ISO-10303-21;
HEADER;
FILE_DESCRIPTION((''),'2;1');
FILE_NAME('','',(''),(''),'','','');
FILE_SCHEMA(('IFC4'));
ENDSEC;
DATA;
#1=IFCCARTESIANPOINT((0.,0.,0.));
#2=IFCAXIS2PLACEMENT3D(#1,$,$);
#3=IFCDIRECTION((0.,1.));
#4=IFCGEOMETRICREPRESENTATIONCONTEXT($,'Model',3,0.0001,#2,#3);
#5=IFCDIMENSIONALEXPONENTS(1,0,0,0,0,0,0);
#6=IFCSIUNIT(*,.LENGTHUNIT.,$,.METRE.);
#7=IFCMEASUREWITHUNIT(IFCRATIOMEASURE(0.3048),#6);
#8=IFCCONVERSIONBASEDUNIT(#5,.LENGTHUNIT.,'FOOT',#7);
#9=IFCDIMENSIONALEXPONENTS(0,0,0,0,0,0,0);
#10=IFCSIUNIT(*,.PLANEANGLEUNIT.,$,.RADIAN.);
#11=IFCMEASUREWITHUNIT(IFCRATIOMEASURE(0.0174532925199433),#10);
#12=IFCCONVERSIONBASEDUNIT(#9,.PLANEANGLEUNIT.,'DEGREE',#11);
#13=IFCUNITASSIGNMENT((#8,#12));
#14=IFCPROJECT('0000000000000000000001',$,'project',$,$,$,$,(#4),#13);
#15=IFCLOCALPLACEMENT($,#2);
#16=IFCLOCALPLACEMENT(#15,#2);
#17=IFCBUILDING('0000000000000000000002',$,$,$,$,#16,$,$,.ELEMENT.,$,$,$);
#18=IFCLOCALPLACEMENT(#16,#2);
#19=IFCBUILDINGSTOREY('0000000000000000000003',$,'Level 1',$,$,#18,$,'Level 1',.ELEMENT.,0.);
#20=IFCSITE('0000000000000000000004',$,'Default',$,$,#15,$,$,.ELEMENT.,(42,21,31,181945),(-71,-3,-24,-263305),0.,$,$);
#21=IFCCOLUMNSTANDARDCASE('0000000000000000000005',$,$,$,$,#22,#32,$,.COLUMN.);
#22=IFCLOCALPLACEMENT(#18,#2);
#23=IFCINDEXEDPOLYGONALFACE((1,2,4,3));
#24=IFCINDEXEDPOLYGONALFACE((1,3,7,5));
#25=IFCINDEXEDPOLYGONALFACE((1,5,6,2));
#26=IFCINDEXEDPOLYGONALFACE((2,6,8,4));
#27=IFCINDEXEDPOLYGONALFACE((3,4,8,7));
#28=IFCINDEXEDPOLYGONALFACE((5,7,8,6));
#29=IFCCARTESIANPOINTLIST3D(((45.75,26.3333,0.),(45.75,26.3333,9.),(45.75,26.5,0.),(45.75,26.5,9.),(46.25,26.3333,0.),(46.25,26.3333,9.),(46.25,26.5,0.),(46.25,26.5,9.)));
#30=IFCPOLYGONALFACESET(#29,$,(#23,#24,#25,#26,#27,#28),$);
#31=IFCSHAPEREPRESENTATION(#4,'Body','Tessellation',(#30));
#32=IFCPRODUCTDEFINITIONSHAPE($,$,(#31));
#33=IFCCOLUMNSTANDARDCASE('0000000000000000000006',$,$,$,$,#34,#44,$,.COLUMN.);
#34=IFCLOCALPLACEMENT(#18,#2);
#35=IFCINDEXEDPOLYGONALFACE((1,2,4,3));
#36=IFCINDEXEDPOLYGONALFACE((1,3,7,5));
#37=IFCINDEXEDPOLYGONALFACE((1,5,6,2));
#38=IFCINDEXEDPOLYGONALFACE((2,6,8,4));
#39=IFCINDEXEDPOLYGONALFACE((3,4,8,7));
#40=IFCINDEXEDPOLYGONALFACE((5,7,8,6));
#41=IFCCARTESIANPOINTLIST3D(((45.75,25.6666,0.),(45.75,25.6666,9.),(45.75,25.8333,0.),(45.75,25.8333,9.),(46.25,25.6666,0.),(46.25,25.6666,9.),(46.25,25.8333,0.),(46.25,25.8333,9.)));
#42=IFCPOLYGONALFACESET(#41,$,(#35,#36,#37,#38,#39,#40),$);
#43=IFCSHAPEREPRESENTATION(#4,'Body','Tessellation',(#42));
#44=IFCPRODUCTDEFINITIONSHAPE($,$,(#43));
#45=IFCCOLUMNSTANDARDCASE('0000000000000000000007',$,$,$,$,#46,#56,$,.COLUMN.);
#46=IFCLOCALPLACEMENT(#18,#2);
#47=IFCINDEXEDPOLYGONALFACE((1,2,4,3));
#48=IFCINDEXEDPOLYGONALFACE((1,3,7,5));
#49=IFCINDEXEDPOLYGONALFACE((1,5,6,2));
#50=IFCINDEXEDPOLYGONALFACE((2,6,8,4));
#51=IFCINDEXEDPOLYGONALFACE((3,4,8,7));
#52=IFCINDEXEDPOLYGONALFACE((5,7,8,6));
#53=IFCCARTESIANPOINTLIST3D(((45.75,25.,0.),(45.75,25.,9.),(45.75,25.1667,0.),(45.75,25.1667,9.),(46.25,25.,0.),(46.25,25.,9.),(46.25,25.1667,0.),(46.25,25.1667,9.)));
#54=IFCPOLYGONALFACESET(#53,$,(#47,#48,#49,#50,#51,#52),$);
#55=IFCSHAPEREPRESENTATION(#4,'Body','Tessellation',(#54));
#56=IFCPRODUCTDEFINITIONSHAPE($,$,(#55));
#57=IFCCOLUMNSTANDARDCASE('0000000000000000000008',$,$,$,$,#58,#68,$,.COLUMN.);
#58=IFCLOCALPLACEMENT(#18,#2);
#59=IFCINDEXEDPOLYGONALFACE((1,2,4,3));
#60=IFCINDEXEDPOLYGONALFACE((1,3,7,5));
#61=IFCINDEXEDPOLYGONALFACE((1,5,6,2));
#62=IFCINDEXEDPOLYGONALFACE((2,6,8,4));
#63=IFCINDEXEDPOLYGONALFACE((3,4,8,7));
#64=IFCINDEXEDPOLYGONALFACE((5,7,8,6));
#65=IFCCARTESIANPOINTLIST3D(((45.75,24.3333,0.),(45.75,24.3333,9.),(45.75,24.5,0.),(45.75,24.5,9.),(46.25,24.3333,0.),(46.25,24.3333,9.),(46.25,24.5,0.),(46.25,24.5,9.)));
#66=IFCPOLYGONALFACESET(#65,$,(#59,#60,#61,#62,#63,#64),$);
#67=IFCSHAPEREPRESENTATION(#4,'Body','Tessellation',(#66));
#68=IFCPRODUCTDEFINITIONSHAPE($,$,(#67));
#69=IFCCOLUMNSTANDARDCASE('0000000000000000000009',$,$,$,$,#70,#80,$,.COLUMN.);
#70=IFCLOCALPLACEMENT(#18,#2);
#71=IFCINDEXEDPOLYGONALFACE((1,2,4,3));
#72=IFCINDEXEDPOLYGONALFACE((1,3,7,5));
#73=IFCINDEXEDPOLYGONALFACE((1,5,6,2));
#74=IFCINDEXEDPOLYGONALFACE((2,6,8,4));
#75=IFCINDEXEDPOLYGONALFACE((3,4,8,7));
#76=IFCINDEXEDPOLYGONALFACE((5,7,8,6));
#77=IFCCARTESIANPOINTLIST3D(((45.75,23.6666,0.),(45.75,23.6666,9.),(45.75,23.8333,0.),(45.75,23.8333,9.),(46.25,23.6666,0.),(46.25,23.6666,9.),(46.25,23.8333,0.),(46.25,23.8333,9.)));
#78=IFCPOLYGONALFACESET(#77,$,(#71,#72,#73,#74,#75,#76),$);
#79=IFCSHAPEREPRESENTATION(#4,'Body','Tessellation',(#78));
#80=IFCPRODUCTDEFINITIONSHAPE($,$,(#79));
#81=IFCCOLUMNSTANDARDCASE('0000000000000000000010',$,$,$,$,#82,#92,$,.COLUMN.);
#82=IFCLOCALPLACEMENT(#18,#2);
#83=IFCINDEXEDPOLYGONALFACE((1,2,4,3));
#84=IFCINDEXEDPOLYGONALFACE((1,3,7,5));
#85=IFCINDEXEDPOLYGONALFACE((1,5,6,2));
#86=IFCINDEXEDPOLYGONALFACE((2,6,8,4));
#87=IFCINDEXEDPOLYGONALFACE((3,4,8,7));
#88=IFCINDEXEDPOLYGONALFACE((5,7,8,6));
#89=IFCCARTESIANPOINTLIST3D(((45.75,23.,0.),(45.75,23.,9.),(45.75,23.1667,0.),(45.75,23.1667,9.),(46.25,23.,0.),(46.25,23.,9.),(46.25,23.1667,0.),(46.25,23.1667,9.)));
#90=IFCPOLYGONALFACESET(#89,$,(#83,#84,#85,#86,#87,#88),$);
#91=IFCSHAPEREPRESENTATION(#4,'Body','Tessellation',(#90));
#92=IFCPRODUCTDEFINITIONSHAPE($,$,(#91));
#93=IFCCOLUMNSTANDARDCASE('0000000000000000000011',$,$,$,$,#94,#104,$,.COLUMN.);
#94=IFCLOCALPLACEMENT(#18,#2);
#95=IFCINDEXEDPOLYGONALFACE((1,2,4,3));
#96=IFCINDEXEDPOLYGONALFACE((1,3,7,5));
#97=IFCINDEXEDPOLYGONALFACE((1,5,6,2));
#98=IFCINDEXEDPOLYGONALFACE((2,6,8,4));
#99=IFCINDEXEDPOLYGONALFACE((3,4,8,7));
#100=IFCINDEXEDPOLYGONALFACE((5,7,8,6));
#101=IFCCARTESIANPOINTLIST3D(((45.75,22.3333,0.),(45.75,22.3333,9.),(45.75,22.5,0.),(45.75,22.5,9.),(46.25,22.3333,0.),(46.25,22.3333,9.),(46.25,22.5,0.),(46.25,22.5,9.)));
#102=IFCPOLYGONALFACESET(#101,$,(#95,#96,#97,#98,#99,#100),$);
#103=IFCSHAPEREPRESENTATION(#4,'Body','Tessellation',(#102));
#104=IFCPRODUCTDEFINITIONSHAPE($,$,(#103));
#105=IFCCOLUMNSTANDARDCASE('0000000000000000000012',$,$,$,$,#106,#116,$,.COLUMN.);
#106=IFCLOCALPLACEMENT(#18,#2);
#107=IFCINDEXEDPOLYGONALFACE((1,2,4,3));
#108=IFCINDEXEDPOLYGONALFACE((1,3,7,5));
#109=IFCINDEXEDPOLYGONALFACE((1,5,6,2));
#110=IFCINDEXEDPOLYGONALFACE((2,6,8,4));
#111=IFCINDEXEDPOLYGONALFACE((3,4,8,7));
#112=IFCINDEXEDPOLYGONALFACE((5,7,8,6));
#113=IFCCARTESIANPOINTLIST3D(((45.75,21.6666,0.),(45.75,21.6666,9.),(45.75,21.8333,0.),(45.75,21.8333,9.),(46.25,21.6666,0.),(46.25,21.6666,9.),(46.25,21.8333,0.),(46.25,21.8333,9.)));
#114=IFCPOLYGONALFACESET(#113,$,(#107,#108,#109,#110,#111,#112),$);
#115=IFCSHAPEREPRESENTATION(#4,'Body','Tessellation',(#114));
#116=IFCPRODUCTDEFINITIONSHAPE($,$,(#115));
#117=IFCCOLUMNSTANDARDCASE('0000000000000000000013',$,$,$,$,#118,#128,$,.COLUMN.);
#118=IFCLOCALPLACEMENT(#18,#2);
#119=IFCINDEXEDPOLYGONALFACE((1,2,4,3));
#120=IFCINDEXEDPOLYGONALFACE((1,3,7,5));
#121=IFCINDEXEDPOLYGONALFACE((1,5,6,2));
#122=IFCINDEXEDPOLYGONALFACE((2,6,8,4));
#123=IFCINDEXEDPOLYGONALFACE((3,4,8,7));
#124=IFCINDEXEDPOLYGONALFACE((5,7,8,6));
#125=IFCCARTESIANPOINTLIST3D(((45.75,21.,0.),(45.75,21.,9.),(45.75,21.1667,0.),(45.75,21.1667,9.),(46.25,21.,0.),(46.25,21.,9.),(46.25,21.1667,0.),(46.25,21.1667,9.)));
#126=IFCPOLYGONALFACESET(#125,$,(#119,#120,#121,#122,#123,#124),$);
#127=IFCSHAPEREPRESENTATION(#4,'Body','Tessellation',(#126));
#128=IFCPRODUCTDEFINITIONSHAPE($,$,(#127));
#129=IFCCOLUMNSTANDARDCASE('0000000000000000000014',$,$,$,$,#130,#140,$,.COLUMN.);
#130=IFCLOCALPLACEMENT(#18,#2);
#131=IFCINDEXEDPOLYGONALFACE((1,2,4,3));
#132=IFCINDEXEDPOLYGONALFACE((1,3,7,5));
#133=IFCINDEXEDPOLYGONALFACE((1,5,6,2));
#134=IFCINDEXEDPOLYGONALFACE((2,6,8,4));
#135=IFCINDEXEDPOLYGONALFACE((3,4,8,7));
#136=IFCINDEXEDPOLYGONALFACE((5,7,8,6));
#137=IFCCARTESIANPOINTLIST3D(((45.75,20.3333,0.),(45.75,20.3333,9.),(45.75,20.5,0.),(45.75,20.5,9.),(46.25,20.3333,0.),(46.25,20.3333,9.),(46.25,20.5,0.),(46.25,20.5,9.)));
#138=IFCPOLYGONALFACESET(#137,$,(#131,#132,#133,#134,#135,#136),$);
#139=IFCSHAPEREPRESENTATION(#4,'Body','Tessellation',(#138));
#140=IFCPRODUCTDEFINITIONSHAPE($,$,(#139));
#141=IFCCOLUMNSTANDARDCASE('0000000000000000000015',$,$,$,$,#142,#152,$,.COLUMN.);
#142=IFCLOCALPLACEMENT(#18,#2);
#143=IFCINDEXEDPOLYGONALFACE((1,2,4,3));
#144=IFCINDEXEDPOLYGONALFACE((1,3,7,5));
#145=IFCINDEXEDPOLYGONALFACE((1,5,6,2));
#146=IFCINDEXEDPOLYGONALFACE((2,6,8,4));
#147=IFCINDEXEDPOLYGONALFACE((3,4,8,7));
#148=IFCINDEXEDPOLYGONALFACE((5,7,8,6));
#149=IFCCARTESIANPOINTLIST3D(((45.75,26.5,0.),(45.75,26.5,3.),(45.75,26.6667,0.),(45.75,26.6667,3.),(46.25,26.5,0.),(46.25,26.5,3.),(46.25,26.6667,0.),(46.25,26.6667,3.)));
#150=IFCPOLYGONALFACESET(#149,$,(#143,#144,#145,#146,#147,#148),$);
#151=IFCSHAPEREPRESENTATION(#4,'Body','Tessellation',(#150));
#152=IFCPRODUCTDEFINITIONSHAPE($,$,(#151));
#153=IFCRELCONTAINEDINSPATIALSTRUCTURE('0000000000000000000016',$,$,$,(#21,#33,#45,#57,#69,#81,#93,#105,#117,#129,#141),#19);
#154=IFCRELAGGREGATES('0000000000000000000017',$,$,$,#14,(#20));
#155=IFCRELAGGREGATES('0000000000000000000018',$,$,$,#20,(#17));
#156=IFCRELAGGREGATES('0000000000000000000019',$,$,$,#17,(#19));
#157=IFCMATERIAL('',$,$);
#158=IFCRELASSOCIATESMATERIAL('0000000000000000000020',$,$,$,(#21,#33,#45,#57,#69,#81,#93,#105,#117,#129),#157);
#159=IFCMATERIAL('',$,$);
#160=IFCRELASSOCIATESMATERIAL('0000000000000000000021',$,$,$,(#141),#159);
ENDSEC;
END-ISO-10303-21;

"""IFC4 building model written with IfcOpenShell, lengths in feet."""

from ifc_helpers import new_model, entity, si_unit, converted_unit, direction, frame, origin, place, context, project, spatial, rectangle, extrude, material, element, save


model = new_model("IFC4")

# Units and contexts
model_context = context("Model", 3, precision=0.0001, world=origin(), true_north=direction((0.0, 1.0)))
ifc_project = project(units=[converted_unit("LENGTHUNIT", "FOOT", entity("IfcRatioMeasure", 0.3048), si_unit("LENGTHUNIT", "METRE"), dimensions=[1, 0, 0, 0, 0, 0, 0]), converted_unit("PLANEANGLEUNIT", "DEGREE", entity("IfcRatioMeasure", 0.0174532925199433), si_unit("PLANEANGLEUNIT", "RADIAN"), dimensions=[0, 0, 0, 0, 0, 0, 0])], contexts=[model_context])

# Site, building, storey
site_placement = place(None, origin())
site = spatial("IfcSite", under=ifc_project, at=site_placement, Name="Default", CompositionType="ELEMENT", RefLatitude=(42, 21, 31, 181945), RefLongitude=(-71, -3, -24, -263305), RefElevation=0.0)
building_placement = place(site_placement, origin())
building = spatial("IfcBuilding", under=site, at=building_placement, CompositionType="ELEMENT")
storey_placement = place(building_placement, origin())
storey = spatial("IfcBuildingStorey", under=building, at=storey_placement, Name="Level 1", LongName="Level 1", CompositionType="ELEMENT", Elevation=0.0)

# Columns
ifc_material_1 = material(Name="")
placement_1 = place(storey_placement, frame((46.0, 46.25, 0.0), z_axis=(0.0, 0.0, 1.0), x_axis=(0.0, -1.0, 0.0)))
for number, where, z_axis, x_axis in (
    (1, (19.8334, 0.0, 0.0), (0.0, 0.0, 1.0), (1.0, 0.0, 0.0)),
    (2, (20.5, 0.0, 0.0), (0.0, 0.0, 1.0), (1.0, 0.0, 0.0)),
    (3, (21.1667, 0.0, 0.0), (0.0, 0.0, 1.0), (1.0, 0.0, 0.0)),
    (4, (21.8333, 0.0, 0.0), (0.0, 0.0, 1.0), (1.0, 0.0, 0.0)),
    (5, (22.5, 0.0, 0.0), (0.0, 0.0, 1.0), (1.0, 0.0, 0.0)),
    (6, (23.1667, 0.0, 0.0), (0.0, 0.0, 1.0), (1.0, 0.0, 0.0)),
    (7, (23.8333, 0.0, 0.0), (0.0, 0.0, 1.0), (1.0, 0.0, 0.0)),
    (8, (24.5, 0.0, 0.0), (0.0, 0.0, 1.0), (1.0, 0.0, 0.0)),
    (9, (25.1667, 0.0, 0.0), (0.0, 0.0, 1.0), (1.0, 0.0, 0.0)),
    (10, (25.8333, 0.0, 0.0), (0.0, 0.0, 1.0), (1.0, 0.0, 0.0)),
):
    element("IfcColumnStandardCase", number, at=place(placement_1, frame(where, z_axis=z_axis, x_axis=x_axis)), inside=storey, material=ifc_material_1, PredefinedType="COLUMN", context=model_context, shape_type="SweptSolid", body=[
        extrude(rectangle(XDim=0.1667, YDim=0.5), origin(), (0.0, 0.0, 1.0), 9.0),
    ])
ifc_material_2 = material(Name="")
for number, where, z_axis, x_axis in (
    (11, (19.6667, 0.0, 0.0), (0.0, 0.0, 1.0), (1.0, 0.0, 0.0)),
):
    element("IfcColumnStandardCase", number, at=place(placement_1, frame(where, z_axis=z_axis, x_axis=x_axis)), inside=storey, material=ifc_material_2, PredefinedType="COLUMN", context=model_context, shape_type="SweptSolid", body=[
        extrude(rectangle(XDim=0.1667, YDim=0.5), origin(), (0.0, 0.0, 1.0), 3.0),
    ])

save(model, "model.ifc")
